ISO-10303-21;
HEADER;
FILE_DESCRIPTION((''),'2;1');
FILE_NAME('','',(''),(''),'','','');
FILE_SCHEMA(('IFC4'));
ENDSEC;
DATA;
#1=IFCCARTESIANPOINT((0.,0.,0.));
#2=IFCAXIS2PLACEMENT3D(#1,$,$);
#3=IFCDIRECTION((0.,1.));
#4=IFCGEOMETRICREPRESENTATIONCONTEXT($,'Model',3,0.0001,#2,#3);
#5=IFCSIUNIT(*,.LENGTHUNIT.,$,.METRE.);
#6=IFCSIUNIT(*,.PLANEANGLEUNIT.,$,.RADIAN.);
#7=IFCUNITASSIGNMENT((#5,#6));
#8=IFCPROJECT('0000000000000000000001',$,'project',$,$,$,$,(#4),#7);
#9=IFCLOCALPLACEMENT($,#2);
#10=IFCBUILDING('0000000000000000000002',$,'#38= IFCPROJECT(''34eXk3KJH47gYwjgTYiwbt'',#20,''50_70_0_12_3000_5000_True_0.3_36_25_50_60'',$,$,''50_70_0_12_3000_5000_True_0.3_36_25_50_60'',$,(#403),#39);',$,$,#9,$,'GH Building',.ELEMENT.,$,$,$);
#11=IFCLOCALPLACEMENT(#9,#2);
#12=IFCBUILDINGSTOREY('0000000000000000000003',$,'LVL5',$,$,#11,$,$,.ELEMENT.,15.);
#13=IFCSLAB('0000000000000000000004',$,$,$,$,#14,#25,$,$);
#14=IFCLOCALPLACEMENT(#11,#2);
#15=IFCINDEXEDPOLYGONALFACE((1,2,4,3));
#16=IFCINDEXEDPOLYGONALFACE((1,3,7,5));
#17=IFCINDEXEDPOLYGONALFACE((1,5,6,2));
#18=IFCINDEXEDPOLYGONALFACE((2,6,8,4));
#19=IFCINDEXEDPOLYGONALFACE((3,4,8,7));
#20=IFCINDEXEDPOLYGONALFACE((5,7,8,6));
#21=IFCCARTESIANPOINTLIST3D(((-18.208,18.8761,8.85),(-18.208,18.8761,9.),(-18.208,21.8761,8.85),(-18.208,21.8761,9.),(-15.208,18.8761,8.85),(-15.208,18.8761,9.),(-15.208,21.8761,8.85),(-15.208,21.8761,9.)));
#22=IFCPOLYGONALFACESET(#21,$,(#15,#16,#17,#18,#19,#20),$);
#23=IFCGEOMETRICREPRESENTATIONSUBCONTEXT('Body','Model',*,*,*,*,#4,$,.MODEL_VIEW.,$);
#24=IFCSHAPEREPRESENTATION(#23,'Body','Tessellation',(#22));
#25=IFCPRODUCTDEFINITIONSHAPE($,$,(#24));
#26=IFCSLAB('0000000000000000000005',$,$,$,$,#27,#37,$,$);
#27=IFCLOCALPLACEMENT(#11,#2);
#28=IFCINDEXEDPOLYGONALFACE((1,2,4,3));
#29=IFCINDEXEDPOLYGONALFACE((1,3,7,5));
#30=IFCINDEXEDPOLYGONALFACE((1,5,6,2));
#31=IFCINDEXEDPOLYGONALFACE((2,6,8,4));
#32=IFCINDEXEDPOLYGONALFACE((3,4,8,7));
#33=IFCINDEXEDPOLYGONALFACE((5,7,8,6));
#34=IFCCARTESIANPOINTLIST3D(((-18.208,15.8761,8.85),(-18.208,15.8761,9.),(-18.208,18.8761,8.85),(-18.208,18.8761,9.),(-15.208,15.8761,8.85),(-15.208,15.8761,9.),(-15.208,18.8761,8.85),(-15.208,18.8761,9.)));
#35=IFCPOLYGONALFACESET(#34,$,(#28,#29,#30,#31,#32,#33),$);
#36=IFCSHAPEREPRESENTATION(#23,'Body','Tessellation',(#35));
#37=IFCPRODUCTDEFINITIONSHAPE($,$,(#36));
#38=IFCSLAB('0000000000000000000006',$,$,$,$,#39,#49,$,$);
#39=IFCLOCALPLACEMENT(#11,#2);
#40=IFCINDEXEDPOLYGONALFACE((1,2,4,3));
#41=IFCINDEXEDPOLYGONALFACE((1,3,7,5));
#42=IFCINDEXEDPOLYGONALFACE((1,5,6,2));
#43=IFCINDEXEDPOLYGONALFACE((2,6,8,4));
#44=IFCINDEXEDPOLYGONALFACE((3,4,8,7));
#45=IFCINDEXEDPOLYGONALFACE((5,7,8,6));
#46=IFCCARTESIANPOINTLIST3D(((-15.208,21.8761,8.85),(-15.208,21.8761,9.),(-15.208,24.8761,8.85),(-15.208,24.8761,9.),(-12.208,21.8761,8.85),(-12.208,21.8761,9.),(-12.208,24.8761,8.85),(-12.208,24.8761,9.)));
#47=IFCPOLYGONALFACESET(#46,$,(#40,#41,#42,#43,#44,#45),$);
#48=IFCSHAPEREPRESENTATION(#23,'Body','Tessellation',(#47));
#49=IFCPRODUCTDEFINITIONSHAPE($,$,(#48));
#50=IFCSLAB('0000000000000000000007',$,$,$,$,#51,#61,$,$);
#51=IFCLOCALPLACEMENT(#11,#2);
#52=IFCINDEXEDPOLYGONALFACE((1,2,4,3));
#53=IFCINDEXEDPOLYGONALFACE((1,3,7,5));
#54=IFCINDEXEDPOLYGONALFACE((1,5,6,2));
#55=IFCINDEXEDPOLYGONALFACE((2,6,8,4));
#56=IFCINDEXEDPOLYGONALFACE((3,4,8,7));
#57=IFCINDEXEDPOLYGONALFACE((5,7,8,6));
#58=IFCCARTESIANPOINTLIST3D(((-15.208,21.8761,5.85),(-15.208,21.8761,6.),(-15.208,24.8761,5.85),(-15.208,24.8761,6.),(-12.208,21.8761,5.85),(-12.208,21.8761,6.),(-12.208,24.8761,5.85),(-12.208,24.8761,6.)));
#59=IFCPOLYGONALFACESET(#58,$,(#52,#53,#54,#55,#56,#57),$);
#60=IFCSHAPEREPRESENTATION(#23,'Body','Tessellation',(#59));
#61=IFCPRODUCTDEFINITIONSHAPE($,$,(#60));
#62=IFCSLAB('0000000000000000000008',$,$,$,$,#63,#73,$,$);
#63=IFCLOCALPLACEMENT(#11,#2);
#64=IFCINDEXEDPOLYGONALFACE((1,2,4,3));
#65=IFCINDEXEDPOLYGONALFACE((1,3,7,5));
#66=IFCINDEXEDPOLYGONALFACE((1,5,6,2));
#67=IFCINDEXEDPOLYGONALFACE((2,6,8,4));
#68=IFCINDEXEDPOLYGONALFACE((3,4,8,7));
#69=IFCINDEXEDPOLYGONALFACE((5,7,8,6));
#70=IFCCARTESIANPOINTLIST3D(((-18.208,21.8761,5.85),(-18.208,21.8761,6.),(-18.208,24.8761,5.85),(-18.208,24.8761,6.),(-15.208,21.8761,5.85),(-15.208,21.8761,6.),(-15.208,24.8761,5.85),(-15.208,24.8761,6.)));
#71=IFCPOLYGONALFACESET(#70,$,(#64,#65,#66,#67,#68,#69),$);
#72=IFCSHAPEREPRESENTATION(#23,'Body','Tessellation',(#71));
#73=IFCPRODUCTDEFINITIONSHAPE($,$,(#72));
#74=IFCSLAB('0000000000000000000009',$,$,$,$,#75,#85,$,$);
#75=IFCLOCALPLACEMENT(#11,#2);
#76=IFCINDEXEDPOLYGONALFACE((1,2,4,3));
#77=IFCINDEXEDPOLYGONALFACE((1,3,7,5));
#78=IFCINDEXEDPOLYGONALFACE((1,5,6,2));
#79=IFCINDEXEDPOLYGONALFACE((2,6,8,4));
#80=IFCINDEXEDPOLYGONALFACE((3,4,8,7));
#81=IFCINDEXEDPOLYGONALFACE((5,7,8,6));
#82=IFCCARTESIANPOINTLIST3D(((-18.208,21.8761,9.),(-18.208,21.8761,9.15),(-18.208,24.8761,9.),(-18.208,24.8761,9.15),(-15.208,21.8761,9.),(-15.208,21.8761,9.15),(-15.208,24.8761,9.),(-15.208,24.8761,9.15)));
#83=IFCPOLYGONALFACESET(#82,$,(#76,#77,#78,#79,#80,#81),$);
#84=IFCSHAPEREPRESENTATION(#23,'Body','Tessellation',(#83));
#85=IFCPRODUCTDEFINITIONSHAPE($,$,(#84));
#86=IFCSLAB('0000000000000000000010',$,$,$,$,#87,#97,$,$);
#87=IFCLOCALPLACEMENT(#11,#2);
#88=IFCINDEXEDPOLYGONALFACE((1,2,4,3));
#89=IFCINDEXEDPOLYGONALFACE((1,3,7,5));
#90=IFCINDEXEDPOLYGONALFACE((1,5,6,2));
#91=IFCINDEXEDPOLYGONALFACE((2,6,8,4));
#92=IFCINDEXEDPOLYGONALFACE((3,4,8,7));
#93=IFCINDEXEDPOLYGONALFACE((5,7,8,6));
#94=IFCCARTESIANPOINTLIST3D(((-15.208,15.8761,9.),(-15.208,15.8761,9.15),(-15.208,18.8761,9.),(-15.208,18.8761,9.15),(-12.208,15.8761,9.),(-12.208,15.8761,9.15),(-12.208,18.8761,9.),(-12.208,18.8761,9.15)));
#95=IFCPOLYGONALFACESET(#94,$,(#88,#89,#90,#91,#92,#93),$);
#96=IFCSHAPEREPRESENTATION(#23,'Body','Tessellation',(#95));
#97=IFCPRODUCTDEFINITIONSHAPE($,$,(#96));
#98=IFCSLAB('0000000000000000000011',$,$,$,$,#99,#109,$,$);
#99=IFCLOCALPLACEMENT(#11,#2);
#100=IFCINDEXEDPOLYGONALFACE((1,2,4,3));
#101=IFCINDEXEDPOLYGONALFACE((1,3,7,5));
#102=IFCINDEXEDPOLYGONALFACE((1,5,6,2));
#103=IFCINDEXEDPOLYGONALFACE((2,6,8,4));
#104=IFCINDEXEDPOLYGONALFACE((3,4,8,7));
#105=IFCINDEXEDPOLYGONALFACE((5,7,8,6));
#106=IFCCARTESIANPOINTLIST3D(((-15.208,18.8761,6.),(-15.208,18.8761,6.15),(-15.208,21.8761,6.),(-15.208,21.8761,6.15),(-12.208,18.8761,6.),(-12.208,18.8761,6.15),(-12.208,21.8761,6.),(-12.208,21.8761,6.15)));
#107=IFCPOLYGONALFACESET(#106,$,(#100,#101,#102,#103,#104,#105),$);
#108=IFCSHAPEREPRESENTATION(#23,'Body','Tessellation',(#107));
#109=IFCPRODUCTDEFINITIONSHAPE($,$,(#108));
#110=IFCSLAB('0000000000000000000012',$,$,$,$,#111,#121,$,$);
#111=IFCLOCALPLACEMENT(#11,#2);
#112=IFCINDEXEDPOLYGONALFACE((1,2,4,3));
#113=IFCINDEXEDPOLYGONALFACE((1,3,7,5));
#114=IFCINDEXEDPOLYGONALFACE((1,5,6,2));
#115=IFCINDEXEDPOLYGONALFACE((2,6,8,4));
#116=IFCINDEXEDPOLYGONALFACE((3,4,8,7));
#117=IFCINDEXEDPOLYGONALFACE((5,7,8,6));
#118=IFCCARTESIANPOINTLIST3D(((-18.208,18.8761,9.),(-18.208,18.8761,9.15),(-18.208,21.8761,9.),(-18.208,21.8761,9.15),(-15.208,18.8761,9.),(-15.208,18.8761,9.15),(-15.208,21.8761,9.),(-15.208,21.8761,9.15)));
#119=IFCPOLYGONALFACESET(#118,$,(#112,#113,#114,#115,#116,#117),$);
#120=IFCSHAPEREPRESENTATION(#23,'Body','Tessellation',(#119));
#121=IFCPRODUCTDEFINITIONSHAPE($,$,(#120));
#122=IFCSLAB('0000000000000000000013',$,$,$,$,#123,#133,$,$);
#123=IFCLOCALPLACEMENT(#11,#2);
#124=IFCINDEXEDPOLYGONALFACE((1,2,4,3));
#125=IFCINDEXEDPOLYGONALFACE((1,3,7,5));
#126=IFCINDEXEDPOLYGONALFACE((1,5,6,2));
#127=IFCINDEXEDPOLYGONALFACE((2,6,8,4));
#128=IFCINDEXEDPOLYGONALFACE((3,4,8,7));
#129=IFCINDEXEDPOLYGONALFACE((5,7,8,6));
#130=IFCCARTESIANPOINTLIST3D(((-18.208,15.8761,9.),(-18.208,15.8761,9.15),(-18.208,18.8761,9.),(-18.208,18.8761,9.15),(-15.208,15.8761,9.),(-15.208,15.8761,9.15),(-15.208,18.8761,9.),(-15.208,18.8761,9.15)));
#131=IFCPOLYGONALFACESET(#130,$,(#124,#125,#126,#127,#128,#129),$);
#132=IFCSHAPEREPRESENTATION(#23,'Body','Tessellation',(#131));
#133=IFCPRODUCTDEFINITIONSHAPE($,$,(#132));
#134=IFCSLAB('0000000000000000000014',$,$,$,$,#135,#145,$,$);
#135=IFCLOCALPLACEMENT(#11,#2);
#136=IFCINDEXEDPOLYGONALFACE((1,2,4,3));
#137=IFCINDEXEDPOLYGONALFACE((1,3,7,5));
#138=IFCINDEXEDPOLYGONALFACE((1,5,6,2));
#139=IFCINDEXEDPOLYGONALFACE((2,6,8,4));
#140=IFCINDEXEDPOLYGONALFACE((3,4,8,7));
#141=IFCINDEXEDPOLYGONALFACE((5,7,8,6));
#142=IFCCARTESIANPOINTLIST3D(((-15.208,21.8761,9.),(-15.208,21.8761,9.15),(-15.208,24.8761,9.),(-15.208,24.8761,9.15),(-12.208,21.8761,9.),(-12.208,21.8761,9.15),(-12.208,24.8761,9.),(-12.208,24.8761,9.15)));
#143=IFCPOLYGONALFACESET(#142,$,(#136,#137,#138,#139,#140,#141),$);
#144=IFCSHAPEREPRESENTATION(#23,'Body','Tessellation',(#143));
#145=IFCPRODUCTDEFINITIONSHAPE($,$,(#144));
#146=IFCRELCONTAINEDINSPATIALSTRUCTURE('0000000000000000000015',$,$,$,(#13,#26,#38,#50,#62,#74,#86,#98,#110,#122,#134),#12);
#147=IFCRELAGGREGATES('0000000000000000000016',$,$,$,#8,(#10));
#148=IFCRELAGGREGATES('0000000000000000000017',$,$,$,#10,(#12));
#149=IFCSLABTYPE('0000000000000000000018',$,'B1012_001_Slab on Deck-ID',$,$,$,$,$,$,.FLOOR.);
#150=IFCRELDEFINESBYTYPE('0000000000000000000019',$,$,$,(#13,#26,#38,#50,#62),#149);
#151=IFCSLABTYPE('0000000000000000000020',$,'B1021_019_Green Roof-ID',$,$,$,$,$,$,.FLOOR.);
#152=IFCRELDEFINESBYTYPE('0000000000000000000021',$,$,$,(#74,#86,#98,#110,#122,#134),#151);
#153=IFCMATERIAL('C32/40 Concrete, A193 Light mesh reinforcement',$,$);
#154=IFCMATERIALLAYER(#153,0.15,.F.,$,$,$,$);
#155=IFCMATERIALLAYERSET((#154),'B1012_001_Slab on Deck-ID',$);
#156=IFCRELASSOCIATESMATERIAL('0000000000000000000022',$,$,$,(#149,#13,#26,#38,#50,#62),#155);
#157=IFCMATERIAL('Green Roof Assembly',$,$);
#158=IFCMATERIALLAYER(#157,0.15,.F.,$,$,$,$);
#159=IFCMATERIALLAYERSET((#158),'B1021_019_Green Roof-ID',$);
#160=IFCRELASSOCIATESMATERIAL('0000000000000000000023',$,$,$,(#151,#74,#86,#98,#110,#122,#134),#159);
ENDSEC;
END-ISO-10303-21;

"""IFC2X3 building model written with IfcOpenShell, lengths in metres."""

from ifc_helpers import new_model, si_unit, direction, frame, origin, place, context, subcontext, project, spatial, polyline, outline, extrude, material, layer, layer_set, layer_usage, type_object, element, save


model = new_model("IFC2X3")

# Units and contexts
model_context = context("Model", 3, precision=0.0001, world=origin(), true_north=direction((0.0, 1.0)))
body_context = subcontext(model_context, "Body", "Model", "MODEL_VIEW")
ifc_project = project(units=[si_unit("LENGTHUNIT", "METRE"), si_unit("PLANEANGLEUNIT", "RADIAN")], contexts=[model_context])

# Building, storey
building_placement = place(None, origin())
building = spatial("IfcBuilding", under=ifc_project, at=building_placement, Name="#38= IFCPROJECT('34eXk3KJH47gYwjgTYiwbt',#20,'50_70_0_12_3000_5000_True_0.3_36_25_50_60',$,$,'50_70_0_12_3000_5000_True_0.3_36_25_50_60',$,(#403),#39);", LongName="GH Building", CompositionType="ELEMENT")
storey_placement = place(building_placement, origin())
storey = spatial("IfcBuildingStorey", under=building, at=storey_placement, Name="LVL5", CompositionType="ELEMENT", Elevation=15.0)

# Slabs
ifc_material_1 = material(Name="C32/40 Concrete, A193 Light mesh reinforcement")
ifc_layer_1 = layer(ifc_material_1, 0.15, ventilated=False)
ifc_layer_set_1 = layer_set([ifc_layer_1], Name="B1012_001_Slab on Deck-ID")
slab_type_1 = type_object("IfcSlabType", Name="B1012_001_Slab on Deck-ID", PredefinedType="FLOOR", material=ifc_layer_set_1)
ifc_layer_usage_1 = layer_usage(ifc_layer_set_1, "AXIS3", "NEGATIVE", -0.15)
slab_1_placement = place(storey_placement, frame((-16.708, 20.3761, 8.85)))
element("IfcSlab", 1, at=slab_1_placement, inside=storey, type_object=slab_type_1, material=ifc_layer_usage_1, context=body_context, shape_type="SweptSolid", body=[
    extrude(outline(polyline([(1.5, -1.5), (-1.5, -1.5), (-1.5, 1.5), (1.5, 1.5), (1.5, -1.5)])), origin(), (0.0, 0.0, 1.0), 0.15),
])
ifc_layer_usage_2 = layer_usage(ifc_layer_set_1, "AXIS3", "NEGATIVE", -0.15)
slab_2_placement = place(storey_placement, frame((-16.708, 17.3761, 8.85)))
element("IfcSlab", 2, at=slab_2_placement, inside=storey, type_object=slab_type_1, material=ifc_layer_usage_2, context=body_context, shape_type="SweptSolid", body=[
    extrude(outline(polyline([(1.5, -1.5), (-1.5, -1.5), (-1.5, 1.5), (1.5, 1.5), (1.5, -1.5)])), origin(), (0.0, 0.0, 1.0), 0.15),
])
ifc_layer_usage_3 = layer_usage(ifc_layer_set_1, "AXIS3", "NEGATIVE", -0.15)
slab_3_placement = place(storey_placement, frame((-13.708, 23.3761, 8.85)))
element("IfcSlab", 3, at=slab_3_placement, inside=storey, type_object=slab_type_1, material=ifc_layer_usage_3, context=body_context, shape_type="SweptSolid", body=[
    extrude(outline(polyline([(1.5, -1.5), (-1.5, -1.5), (-1.5, 1.5), (1.5, 1.5), (1.5, -1.5)])), origin(), (0.0, 0.0, 1.0), 0.15),
])
ifc_layer_usage_4 = layer_usage(ifc_layer_set_1, "AXIS3", "NEGATIVE", -0.15)
slab_4_placement = place(storey_placement, frame((-13.708, 23.3761, 5.85)))
element("IfcSlab", 4, at=slab_4_placement, inside=storey, type_object=slab_type_1, material=ifc_layer_usage_4, context=body_context, shape_type="SweptSolid", body=[
    extrude(outline(polyline([(1.5, -1.5), (-1.5, -1.5), (-1.5, 1.5), (1.5, 1.5), (1.5, -1.5)])), origin(), (0.0, 0.0, 1.0), 0.15),
])
ifc_layer_usage_5 = layer_usage(ifc_layer_set_1, "AXIS3", "NEGATIVE", -0.15)
slab_5_placement = place(storey_placement, frame((-16.708, 23.3761, 5.85)))
element("IfcSlab", 5, at=slab_5_placement, inside=storey, type_object=slab_type_1, material=ifc_layer_usage_5, context=body_context, shape_type="SweptSolid", body=[
    extrude(outline(polyline([(1.5, -1.5), (-1.5, -1.5), (-1.5, 1.5), (1.5, 1.5), (1.5, -1.5)])), origin(), (0.0, 0.0, 1.0), 0.15),
])
ifc_material_2 = material(Name="Green Roof Assembly")
ifc_layer_2 = layer(ifc_material_2, 0.15, ventilated=False)
ifc_layer_set_2 = layer_set([ifc_layer_2], Name="B1021_019_Green Roof-ID")
ifc_layer_usage_6 = layer_usage(ifc_layer_set_2, "AXIS3", "NEGATIVE", -0.15)
slab_type_2 = type_object("IfcSlabType", Name="B1021_019_Green Roof-ID", PredefinedType="FLOOR", material=ifc_layer_set_2)
slab_6_placement = place(storey_placement, frame((-16.708, 23.3761, 9.0)))
element("IfcSlab", 6, at=slab_6_placement, inside=storey, type_object=slab_type_2, material=ifc_layer_usage_6, context=body_context, shape_type="SweptSolid", body=[
    extrude(outline(polyline([(1.5, -1.5), (-1.5, -1.5), (-1.5, 1.5), (1.5, 1.5), (1.5, -1.5)])), origin(), (0.0, 0.0, 1.0), 0.15),
])
ifc_layer_usage_7 = layer_usage(ifc_layer_set_2, "AXIS3", "NEGATIVE", -0.15)
slab_7_placement = place(storey_placement, frame((-13.708, 17.3761, 9.0)))
element("IfcSlab", 7, at=slab_7_placement, inside=storey, type_object=slab_type_2, material=ifc_layer_usage_7, context=body_context, shape_type="SweptSolid", body=[
    extrude(outline(polyline([(1.5, -1.5), (-1.5, -1.5), (-1.5, 1.5), (1.5, 1.5), (1.5, -1.5)])), origin(), (0.0, 0.0, 1.0), 0.15),
])
ifc_layer_usage_8 = layer_usage(ifc_layer_set_2, "AXIS3", "NEGATIVE", -0.15)
slab_8_placement = place(storey_placement, frame((-13.708, 20.3761, 6.0)))
element("IfcSlab", 8, at=slab_8_placement, inside=storey, type_object=slab_type_2, material=ifc_layer_usage_8, context=body_context, shape_type="SweptSolid", body=[
    extrude(outline(polyline([(-1.5, -1.5), (-1.5, 1.5), (1.5, 1.5), (1.5, -1.5), (-1.5, -1.5)])), origin(), (0.0, 0.0, 1.0), 0.15),
])
ifc_layer_usage_9 = layer_usage(ifc_layer_set_2, "AXIS3", "NEGATIVE", -0.15)
slab_9_placement = place(storey_placement, frame((-16.708, 20.3761, 9.0)))
element("IfcSlab", 9, at=slab_9_placement, inside=storey, type_object=slab_type_2, material=ifc_layer_usage_9, context=body_context, shape_type="SweptSolid", body=[
    extrude(outline(polyline([(1.5, -1.5), (-1.5, -1.5), (-1.5, 1.5), (1.5, 1.5), (1.5, -1.5)])), origin(), (0.0, 0.0, 1.0), 0.15),
])
ifc_layer_usage_10 = layer_usage(ifc_layer_set_2, "AXIS3", "NEGATIVE", -0.15)
slab_10_placement = place(storey_placement, frame((-16.708, 17.3761, 9.0)))
element("IfcSlab", 10, at=slab_10_placement, inside=storey, type_object=slab_type_2, material=ifc_layer_usage_10, context=body_context, shape_type="SweptSolid", body=[
    extrude(outline(polyline([(1.5, -1.5), (-1.5, -1.5), (-1.5, 1.5), (1.5, 1.5), (1.5, -1.5)])), origin(), (0.0, 0.0, 1.0), 0.15),
])
ifc_layer_usage_11 = layer_usage(ifc_layer_set_2, "AXIS3", "NEGATIVE", -0.15)
slab_11_placement = place(storey_placement, frame((-13.708, 23.3761, 9.0)))
element("IfcSlab", 11, at=slab_11_placement, inside=storey, type_object=slab_type_2, material=ifc_layer_usage_11, context=body_context, shape_type="SweptSolid", body=[
    extrude(outline(polyline([(1.5, -1.5), (-1.5, -1.5), (-1.5, 1.5), (1.5, 1.5), (1.5, -1.5)])), origin(), (0.0, 0.0, 1.0), 0.15),
])

save(model, "model.ifc")
